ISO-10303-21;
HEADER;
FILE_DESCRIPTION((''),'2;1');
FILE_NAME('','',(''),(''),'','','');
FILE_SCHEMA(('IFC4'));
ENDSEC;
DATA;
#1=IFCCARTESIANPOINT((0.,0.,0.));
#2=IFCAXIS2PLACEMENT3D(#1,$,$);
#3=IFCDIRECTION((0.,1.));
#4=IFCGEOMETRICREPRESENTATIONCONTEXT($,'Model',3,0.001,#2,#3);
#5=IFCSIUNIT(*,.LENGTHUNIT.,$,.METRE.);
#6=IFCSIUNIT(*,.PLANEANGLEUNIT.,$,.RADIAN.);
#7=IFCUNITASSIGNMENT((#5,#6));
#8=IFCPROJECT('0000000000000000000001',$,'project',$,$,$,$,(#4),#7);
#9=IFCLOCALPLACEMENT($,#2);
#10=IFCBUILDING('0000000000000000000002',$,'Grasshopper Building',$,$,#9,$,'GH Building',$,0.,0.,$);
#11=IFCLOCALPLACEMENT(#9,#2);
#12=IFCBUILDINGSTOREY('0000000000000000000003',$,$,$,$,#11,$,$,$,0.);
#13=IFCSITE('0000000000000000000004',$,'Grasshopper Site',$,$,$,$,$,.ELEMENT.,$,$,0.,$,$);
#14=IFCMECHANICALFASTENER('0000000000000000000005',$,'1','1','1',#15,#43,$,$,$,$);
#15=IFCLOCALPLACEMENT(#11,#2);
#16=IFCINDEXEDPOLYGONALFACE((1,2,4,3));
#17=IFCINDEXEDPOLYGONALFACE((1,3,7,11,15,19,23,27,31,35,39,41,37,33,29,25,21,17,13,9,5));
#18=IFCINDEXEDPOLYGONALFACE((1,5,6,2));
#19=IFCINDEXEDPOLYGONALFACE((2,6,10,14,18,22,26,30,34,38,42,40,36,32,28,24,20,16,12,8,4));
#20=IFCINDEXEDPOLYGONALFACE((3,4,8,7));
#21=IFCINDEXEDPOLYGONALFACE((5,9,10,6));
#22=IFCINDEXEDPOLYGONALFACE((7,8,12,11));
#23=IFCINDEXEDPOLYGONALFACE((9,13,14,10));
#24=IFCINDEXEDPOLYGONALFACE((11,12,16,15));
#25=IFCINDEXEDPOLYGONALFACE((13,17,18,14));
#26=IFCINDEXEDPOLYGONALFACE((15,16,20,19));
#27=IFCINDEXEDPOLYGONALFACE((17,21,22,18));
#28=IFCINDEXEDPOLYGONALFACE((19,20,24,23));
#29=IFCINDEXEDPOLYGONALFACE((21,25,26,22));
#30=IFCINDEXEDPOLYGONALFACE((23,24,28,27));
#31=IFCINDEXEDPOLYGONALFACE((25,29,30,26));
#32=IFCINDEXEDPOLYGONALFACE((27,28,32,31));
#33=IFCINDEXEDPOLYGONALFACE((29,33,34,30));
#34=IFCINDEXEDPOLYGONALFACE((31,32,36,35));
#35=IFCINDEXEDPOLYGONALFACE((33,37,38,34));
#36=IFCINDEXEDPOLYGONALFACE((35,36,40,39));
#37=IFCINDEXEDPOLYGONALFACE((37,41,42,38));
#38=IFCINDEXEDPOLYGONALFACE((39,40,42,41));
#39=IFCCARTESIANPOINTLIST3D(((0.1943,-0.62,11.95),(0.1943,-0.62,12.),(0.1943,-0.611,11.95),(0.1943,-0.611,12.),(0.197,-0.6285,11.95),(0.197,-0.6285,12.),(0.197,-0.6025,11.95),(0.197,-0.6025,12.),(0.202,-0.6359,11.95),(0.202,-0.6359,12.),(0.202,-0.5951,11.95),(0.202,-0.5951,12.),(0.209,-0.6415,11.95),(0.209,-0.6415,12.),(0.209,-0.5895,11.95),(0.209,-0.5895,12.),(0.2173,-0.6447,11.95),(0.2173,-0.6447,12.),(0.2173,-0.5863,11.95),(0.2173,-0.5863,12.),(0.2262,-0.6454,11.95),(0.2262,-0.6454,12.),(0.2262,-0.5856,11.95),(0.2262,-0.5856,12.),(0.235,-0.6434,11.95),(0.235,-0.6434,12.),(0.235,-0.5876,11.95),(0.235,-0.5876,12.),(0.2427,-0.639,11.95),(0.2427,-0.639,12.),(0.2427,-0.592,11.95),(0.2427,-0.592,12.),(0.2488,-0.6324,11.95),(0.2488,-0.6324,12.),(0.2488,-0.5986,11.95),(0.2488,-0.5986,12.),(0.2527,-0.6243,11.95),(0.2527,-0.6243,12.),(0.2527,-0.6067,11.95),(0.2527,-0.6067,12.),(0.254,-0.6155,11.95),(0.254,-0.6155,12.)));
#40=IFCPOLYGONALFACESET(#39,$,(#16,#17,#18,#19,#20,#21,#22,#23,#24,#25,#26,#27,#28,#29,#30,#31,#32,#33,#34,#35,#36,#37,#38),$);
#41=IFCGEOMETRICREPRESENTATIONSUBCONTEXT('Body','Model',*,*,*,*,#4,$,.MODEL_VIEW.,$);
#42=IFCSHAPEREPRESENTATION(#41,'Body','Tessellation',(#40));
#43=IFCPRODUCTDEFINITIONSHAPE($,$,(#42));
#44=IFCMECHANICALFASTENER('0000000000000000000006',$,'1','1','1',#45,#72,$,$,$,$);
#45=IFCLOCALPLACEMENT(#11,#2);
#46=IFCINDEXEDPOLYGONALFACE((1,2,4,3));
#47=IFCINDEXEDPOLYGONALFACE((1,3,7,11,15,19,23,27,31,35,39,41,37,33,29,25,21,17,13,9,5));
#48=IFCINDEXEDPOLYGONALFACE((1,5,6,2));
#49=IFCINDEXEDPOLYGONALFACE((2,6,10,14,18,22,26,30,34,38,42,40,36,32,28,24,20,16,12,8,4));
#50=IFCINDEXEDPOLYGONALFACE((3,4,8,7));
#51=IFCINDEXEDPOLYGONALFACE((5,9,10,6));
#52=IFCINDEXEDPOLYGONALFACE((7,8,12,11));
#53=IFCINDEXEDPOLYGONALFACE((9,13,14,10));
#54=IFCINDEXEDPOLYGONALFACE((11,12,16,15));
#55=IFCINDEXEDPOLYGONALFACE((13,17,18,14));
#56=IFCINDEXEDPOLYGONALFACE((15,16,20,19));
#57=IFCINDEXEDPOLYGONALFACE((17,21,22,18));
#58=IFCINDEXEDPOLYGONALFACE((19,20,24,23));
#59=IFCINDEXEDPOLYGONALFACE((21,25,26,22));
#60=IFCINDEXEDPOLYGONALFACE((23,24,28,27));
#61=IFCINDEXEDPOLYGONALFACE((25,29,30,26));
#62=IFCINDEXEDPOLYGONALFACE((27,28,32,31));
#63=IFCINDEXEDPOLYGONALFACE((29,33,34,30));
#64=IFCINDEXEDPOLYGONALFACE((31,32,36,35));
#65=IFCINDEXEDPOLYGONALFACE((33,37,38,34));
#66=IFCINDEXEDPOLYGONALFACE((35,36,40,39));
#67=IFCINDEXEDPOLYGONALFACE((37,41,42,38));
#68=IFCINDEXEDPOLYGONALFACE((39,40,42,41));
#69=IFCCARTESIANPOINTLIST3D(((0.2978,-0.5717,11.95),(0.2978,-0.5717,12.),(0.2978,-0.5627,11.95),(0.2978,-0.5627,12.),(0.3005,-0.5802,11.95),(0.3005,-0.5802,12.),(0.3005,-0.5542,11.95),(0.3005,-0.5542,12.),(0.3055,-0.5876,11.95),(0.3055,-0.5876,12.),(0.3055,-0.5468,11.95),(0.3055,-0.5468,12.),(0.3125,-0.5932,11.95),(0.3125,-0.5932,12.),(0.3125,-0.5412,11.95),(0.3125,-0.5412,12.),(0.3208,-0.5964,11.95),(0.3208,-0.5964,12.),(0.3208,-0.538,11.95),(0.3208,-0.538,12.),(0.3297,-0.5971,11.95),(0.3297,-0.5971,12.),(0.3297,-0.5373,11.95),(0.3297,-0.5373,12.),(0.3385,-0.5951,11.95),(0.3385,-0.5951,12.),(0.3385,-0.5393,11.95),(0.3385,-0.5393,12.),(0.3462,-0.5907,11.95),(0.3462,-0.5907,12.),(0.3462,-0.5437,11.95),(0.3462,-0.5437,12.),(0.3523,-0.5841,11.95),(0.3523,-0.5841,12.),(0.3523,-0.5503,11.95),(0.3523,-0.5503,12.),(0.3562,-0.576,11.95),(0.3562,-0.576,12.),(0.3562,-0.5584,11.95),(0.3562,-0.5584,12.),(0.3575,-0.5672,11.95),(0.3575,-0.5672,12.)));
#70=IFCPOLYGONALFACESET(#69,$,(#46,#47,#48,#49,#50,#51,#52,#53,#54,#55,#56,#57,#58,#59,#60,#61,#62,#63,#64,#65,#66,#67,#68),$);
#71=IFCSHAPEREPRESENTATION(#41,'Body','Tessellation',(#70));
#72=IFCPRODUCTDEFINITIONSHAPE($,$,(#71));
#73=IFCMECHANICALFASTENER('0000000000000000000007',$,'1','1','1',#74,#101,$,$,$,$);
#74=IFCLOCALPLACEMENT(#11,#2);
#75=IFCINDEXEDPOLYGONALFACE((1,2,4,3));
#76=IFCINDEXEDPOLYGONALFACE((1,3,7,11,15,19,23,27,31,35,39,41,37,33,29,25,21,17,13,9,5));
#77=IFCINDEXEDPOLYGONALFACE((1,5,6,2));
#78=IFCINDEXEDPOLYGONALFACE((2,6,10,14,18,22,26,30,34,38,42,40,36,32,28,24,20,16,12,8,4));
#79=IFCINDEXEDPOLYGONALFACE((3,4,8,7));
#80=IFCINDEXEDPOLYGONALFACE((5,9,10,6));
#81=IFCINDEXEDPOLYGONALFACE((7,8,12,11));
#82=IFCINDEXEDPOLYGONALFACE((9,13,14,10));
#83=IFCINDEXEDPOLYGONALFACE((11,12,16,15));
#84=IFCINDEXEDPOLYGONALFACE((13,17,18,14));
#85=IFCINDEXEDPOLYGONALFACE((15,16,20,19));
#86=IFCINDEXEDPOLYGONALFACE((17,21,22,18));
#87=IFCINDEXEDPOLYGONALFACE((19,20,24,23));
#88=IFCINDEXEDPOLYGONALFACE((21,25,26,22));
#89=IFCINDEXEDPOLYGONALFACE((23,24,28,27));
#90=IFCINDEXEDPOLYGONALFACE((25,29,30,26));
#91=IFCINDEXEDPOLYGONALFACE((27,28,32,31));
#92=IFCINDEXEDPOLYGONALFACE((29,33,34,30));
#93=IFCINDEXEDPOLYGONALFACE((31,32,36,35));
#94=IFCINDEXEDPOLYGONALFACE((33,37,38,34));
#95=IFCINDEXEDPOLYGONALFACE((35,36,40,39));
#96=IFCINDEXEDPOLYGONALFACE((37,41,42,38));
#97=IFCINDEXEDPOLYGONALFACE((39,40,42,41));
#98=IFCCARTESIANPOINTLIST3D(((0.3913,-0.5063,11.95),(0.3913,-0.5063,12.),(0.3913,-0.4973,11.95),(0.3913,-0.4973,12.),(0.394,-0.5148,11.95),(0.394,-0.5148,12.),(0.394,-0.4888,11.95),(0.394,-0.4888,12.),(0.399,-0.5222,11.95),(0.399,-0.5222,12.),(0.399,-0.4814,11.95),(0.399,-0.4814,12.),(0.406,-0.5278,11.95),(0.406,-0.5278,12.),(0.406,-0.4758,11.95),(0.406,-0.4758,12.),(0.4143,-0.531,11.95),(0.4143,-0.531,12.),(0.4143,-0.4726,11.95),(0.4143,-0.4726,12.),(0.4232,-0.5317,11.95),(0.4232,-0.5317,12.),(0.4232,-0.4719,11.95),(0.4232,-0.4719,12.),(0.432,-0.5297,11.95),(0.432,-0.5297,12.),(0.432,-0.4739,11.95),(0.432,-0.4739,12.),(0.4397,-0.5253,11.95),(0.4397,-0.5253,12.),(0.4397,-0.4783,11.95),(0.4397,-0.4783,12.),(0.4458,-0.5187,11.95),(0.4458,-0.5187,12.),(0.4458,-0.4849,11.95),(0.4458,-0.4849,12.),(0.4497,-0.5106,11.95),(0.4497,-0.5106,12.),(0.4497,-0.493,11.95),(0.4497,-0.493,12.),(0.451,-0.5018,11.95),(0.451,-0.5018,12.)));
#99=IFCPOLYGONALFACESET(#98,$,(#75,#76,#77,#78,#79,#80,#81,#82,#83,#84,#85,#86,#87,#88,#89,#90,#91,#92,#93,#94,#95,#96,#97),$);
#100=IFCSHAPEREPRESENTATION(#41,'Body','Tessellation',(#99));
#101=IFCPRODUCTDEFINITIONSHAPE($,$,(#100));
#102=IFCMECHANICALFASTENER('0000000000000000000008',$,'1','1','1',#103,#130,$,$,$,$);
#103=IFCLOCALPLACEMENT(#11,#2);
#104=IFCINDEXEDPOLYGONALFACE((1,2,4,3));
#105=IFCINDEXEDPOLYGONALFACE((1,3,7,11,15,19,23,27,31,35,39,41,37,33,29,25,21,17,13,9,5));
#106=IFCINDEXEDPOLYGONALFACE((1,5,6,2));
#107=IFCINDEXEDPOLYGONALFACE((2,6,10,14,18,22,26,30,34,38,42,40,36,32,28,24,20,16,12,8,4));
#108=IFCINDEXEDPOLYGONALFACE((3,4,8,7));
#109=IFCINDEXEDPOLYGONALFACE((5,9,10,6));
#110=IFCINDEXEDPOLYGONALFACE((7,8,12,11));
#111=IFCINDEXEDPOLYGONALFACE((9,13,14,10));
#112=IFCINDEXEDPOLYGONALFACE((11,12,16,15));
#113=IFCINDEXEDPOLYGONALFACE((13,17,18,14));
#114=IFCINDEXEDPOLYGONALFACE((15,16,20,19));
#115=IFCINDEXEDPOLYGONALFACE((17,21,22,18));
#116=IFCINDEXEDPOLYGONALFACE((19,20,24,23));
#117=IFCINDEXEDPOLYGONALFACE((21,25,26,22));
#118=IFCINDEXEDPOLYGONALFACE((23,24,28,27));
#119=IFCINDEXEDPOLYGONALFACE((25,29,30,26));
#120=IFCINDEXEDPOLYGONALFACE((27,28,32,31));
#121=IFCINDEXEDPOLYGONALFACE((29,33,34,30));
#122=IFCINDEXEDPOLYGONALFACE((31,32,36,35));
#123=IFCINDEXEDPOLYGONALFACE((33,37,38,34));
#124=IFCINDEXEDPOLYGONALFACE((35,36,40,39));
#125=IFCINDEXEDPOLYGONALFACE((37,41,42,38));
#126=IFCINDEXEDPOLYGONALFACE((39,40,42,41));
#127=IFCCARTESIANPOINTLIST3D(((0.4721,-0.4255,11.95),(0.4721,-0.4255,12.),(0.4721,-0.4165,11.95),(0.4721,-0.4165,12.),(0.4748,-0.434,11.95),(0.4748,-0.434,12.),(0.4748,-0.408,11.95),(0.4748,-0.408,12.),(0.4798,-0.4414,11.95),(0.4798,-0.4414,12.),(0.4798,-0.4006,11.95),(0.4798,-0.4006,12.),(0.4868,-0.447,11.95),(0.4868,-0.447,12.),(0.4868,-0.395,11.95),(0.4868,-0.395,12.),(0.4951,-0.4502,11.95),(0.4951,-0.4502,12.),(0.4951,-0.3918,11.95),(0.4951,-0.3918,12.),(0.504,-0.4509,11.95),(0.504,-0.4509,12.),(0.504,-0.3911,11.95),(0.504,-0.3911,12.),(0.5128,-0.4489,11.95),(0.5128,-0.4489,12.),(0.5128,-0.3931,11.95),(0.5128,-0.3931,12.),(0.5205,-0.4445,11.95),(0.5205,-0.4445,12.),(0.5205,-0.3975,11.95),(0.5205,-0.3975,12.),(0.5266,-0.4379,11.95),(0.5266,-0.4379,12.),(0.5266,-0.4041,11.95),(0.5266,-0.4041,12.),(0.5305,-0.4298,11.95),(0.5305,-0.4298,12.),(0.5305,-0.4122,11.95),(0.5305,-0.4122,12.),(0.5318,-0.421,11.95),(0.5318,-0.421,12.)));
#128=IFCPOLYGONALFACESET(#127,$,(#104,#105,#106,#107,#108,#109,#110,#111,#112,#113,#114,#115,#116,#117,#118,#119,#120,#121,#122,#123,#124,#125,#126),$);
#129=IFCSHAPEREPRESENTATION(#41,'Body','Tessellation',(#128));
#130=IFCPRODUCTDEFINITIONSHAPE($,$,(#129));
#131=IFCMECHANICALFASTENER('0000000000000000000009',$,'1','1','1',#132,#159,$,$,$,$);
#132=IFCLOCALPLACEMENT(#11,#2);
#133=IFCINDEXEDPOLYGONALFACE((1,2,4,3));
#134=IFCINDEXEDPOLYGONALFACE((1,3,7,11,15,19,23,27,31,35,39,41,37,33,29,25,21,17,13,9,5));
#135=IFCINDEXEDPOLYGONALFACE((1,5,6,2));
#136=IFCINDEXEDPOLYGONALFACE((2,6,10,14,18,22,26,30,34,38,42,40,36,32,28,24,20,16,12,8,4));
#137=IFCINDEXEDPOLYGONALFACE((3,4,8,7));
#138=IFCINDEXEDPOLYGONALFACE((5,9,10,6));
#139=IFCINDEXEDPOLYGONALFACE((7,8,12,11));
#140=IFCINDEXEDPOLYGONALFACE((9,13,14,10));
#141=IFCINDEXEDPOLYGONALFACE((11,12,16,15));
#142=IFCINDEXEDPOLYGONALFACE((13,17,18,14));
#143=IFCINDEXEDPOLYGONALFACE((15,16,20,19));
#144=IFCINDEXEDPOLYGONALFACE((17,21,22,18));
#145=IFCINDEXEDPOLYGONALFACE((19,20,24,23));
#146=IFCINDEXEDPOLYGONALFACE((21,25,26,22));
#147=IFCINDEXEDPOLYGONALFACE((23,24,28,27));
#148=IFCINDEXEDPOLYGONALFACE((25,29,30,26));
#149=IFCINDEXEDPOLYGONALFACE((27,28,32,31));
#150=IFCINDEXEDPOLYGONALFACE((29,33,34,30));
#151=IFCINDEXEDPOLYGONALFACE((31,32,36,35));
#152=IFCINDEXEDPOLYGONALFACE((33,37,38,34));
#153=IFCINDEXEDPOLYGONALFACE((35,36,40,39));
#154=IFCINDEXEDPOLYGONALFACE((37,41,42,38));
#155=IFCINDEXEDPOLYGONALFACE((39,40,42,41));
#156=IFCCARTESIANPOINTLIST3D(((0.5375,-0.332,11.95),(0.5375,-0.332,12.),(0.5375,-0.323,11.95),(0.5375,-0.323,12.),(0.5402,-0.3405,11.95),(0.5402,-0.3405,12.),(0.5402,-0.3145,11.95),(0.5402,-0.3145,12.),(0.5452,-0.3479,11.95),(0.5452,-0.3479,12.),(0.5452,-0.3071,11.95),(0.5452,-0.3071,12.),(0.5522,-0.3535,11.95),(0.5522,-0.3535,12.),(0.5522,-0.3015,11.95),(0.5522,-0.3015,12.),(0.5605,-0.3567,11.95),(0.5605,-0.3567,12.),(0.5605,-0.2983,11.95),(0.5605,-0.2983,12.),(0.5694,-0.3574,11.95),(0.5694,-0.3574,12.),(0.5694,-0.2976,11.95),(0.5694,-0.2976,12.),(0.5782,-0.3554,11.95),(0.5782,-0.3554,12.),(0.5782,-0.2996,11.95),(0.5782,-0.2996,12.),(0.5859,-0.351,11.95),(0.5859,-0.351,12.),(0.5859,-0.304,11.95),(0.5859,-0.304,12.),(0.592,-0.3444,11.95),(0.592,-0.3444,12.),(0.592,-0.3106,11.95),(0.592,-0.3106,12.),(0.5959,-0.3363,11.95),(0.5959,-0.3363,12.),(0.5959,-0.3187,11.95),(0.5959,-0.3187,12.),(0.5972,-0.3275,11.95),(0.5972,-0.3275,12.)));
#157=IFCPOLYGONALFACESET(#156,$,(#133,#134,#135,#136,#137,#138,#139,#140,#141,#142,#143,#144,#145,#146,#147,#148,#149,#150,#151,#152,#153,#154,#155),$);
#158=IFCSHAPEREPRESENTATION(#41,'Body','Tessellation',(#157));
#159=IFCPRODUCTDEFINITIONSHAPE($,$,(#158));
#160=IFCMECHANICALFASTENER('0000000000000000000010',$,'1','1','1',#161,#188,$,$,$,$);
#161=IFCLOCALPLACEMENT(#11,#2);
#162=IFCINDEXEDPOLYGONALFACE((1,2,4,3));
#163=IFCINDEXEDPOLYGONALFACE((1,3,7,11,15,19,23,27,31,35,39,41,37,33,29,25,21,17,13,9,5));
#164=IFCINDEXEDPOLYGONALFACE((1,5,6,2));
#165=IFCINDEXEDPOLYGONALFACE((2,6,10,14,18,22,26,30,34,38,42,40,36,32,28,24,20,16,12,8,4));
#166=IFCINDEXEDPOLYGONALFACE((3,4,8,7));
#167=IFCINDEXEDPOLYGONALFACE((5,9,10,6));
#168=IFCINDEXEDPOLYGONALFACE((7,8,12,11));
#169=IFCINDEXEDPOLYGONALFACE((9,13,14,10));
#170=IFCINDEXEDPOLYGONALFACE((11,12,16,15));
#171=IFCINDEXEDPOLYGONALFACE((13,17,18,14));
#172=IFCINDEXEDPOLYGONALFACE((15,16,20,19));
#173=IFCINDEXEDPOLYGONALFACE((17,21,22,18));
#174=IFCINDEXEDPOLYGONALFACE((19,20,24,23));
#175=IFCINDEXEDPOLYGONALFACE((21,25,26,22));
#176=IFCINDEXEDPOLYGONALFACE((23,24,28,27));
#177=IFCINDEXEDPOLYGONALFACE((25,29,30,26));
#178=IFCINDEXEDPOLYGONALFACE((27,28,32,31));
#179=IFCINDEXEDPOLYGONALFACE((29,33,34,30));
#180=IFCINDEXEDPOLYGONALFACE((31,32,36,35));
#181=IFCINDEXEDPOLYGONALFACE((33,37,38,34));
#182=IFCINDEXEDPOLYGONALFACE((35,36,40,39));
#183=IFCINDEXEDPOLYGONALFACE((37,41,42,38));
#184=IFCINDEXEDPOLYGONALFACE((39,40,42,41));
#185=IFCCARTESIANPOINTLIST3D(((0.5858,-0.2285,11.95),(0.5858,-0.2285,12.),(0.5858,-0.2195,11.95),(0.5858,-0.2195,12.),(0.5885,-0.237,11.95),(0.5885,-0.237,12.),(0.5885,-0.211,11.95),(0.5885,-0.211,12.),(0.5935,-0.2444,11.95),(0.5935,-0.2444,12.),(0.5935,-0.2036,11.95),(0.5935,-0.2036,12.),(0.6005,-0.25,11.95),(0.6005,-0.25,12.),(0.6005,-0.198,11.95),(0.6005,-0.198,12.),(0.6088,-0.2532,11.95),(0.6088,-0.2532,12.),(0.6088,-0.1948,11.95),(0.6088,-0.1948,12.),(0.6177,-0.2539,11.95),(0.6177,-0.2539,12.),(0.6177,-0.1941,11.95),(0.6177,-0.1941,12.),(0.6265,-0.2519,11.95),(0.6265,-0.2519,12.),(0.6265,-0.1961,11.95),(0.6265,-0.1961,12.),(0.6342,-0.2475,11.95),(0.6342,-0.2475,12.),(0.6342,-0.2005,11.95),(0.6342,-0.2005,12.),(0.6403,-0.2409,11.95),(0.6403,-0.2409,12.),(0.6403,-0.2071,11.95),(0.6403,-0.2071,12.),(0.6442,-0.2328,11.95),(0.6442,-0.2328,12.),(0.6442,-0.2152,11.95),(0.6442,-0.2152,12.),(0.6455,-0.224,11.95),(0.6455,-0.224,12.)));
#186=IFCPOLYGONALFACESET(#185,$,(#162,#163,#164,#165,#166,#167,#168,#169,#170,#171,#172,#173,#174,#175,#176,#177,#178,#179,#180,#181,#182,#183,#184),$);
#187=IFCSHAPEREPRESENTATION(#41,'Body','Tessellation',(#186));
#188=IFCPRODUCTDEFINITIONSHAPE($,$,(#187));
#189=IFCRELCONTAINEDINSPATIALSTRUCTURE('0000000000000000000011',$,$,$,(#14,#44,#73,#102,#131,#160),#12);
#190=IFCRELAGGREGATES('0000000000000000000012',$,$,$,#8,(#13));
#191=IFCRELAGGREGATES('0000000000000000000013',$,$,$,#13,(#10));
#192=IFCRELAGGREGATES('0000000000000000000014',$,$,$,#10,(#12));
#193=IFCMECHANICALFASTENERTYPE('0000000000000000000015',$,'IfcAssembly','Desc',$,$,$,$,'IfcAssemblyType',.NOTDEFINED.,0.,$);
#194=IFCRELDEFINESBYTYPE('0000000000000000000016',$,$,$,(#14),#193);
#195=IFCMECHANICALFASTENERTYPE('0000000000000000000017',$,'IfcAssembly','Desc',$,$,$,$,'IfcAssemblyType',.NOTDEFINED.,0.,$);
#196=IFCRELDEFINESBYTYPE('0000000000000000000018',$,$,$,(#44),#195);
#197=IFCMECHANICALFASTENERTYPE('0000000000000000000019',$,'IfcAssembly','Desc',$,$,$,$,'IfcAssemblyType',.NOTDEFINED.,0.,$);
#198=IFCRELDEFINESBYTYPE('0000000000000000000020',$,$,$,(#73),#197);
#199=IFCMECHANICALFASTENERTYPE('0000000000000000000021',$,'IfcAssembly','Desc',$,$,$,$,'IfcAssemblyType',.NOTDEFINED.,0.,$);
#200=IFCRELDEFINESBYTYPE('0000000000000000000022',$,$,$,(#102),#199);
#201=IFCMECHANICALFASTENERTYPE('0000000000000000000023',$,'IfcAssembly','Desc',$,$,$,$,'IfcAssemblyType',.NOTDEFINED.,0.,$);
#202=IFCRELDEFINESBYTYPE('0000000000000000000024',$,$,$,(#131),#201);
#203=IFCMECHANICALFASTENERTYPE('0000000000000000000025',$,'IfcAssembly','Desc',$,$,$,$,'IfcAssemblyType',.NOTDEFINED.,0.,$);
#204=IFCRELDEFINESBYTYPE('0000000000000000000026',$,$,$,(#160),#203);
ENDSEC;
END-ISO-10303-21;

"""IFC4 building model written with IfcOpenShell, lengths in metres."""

from ifc_helpers import new_model, si_unit, direction, frame, origin, place, context, subcontext, project, spatial, circle, extrude, source, transform, mapped, type_object, type_shapes, element, save


model = new_model("IFC4")

# Units and contexts
model_context = context("Model", 3, precision=0.001, world=origin(), true_north=direction((0.0, 1.0)))
body_context = subcontext(model_context, "Body", "Model", "MODEL_VIEW")
ifc_project = project(units=[si_unit("LENGTHUNIT", "METRE"), si_unit("PLANEANGLEUNIT", "RADIAN")], contexts=[model_context])

# Site, building, storey
site = spatial("IfcSite", under=ifc_project, Name="Grasshopper Site", CompositionType="ELEMENT", RefElevation=0.0)
building_placement = place(None, origin())
building = spatial("IfcBuilding", under=site, at=building_placement, Name="Grasshopper Building", LongName="GH Building", ElevationOfRefHeight=0.0, ElevationOfTerrain=0.0)
storey_placement = place(building_placement, origin())
storey = spatial("IfcBuildingStorey", under=building, at=storey_placement, Elevation=0.0)

# Mechanical fasteners
mechanical_fastener_type_1 = type_object("IfcMechanicalFastenerType", Name="IfcAssembly", Description="Desc", ElementType="IfcAssemblyType", NominalDiameter=0.0)
shared_shape_1 = source(origin(), body_context, "Body", "SweptSolid", [
    extrude(circle(Radius=0.03), frame((0.224, -0.6155, 12.0), z_axis=(0.0, 0.0, -1.0), x_axis=(1.0, 0.0, 0.0)), (0.0, 0.0, 1.0), 0.05),
])
type_shapes(mechanical_fastener_type_1, [shared_shape_1])
mechanical_fastener_1_placement = place(storey_placement, origin())
element("IfcMechanicalFastener", 1, at=mechanical_fastener_1_placement, inside=storey, type_object=mechanical_fastener_type_1, Name="1", Description="1", ObjectType="1", context=body_context, shape_type="MappedRepresentation", body=[
    mapped(shared_shape_1, transform((0.0, 0.0, 0.0), scale=1.0)),
])
mechanical_fastener_type_2 = type_object("IfcMechanicalFastenerType", Name="IfcAssembly", Description="Desc", ElementType="IfcAssemblyType", NominalDiameter=0.0)
shared_shape_2 = source(origin(), body_context, "Body", "SweptSolid", [
    extrude(circle(Radius=0.03), frame((0.3275, -0.5672, 12.0), z_axis=(0.0, 0.0, -1.0), x_axis=(1.0, 0.0, 0.0)), (0.0, 0.0, 1.0), 0.05),
])
type_shapes(mechanical_fastener_type_2, [shared_shape_2])
mechanical_fastener_2_placement = place(storey_placement, origin())
element("IfcMechanicalFastener", 2, at=mechanical_fastener_2_placement, inside=storey, type_object=mechanical_fastener_type_2, Name="1", Description="1", ObjectType="1", context=body_context, shape_type="MappedRepresentation", body=[
    mapped(shared_shape_2, transform((0.0, 0.0, 0.0), scale=1.0)),
])
mechanical_fastener_type_3 = type_object("IfcMechanicalFastenerType", Name="IfcAssembly", Description="Desc", ElementType="IfcAssemblyType", NominalDiameter=0.0)
shared_shape_3 = source(origin(), body_context, "Body", "SweptSolid", [
    extrude(circle(Radius=0.03), frame((0.421, -0.5018, 12.0), z_axis=(0.0, 0.0, -1.0), x_axis=(1.0, 0.0, 0.0)), (0.0, 0.0, 1.0), 0.05),
])
type_shapes(mechanical_fastener_type_3, [shared_shape_3])
mechanical_fastener_3_placement = place(storey_placement, origin())
element("IfcMechanicalFastener", 3, at=mechanical_fastener_3_placement, inside=storey, type_object=mechanical_fastener_type_3, Name="1", Description="1", ObjectType="1", context=body_context, shape_type="MappedRepresentation", body=[
    mapped(shared_shape_3, transform((0.0, 0.0, 0.0), scale=1.0)),
])
mechanical_fastener_type_4 = type_object("IfcMechanicalFastenerType", Name="IfcAssembly", Description="Desc", ElementType="IfcAssemblyType", NominalDiameter=0.0)
shared_shape_4 = source(origin(), body_context, "Body", "SweptSolid", [
    extrude(circle(Radius=0.03), frame((0.5018, -0.421, 12.0), z_axis=(0.0, 0.0, -1.0), x_axis=(1.0, 0.0, 0.0)), (0.0, 0.0, 1.0), 0.05),
])
type_shapes(mechanical_fastener_type_4, [shared_shape_4])
mechanical_fastener_4_placement = place(storey_placement, origin())
element("IfcMechanicalFastener", 4, at=mechanical_fastener_4_placement, inside=storey, type_object=mechanical_fastener_type_4, Name="1", Description="1", ObjectType="1", context=body_context, shape_type="MappedRepresentation", body=[
    mapped(shared_shape_4, transform((0.0, 0.0, 0.0), scale=1.0)),
])
mechanical_fastener_type_5 = type_object("IfcMechanicalFastenerType", Name="IfcAssembly", Description="Desc", ElementType="IfcAssemblyType", NominalDiameter=0.0)
shared_shape_5 = source(origin(), body_context, "Body", "SweptSolid", [
    extrude(circle(Radius=0.03), frame((0.5672, -0.3275, 12.0), z_axis=(0.0, 0.0, -1.0), x_axis=(1.0, 0.0, 0.0)), (0.0, 0.0, 1.0), 0.05),
])
type_shapes(mechanical_fastener_type_5, [shared_shape_5])
mechanical_fastener_5_placement = place(storey_placement, origin())
element("IfcMechanicalFastener", 5, at=mechanical_fastener_5_placement, inside=storey, type_object=mechanical_fastener_type_5, Name="1", Description="1", ObjectType="1", context=body_context, shape_type="MappedRepresentation", body=[
    mapped(shared_shape_5, transform((0.0, 0.0, 0.0), scale=1.0)),
])
mechanical_fastener_type_6 = type_object("IfcMechanicalFastenerType", Name="IfcAssembly", Description="Desc", ElementType="IfcAssemblyType", NominalDiameter=0.0)
shared_shape_6 = source(origin(), body_context, "Body", "SweptSolid", [
    extrude(circle(Radius=0.03), frame((0.6155, -0.224, 12.0), z_axis=(0.0, 0.0, -1.0), x_axis=(1.0, 0.0, 0.0)), (0.0, 0.0, 1.0), 0.05),
])
type_shapes(mechanical_fastener_type_6, [shared_shape_6])
mechanical_fastener_6_placement = place(storey_placement, origin())
element("IfcMechanicalFastener", 6, at=mechanical_fastener_6_placement, inside=storey, type_object=mechanical_fastener_type_6, Name="1", Description="1", ObjectType="1", context=body_context, shape_type="MappedRepresentation", body=[
    mapped(shared_shape_6, transform((0.0, 0.0, 0.0), scale=1.0)),
])

save(model, "model.ifc")
